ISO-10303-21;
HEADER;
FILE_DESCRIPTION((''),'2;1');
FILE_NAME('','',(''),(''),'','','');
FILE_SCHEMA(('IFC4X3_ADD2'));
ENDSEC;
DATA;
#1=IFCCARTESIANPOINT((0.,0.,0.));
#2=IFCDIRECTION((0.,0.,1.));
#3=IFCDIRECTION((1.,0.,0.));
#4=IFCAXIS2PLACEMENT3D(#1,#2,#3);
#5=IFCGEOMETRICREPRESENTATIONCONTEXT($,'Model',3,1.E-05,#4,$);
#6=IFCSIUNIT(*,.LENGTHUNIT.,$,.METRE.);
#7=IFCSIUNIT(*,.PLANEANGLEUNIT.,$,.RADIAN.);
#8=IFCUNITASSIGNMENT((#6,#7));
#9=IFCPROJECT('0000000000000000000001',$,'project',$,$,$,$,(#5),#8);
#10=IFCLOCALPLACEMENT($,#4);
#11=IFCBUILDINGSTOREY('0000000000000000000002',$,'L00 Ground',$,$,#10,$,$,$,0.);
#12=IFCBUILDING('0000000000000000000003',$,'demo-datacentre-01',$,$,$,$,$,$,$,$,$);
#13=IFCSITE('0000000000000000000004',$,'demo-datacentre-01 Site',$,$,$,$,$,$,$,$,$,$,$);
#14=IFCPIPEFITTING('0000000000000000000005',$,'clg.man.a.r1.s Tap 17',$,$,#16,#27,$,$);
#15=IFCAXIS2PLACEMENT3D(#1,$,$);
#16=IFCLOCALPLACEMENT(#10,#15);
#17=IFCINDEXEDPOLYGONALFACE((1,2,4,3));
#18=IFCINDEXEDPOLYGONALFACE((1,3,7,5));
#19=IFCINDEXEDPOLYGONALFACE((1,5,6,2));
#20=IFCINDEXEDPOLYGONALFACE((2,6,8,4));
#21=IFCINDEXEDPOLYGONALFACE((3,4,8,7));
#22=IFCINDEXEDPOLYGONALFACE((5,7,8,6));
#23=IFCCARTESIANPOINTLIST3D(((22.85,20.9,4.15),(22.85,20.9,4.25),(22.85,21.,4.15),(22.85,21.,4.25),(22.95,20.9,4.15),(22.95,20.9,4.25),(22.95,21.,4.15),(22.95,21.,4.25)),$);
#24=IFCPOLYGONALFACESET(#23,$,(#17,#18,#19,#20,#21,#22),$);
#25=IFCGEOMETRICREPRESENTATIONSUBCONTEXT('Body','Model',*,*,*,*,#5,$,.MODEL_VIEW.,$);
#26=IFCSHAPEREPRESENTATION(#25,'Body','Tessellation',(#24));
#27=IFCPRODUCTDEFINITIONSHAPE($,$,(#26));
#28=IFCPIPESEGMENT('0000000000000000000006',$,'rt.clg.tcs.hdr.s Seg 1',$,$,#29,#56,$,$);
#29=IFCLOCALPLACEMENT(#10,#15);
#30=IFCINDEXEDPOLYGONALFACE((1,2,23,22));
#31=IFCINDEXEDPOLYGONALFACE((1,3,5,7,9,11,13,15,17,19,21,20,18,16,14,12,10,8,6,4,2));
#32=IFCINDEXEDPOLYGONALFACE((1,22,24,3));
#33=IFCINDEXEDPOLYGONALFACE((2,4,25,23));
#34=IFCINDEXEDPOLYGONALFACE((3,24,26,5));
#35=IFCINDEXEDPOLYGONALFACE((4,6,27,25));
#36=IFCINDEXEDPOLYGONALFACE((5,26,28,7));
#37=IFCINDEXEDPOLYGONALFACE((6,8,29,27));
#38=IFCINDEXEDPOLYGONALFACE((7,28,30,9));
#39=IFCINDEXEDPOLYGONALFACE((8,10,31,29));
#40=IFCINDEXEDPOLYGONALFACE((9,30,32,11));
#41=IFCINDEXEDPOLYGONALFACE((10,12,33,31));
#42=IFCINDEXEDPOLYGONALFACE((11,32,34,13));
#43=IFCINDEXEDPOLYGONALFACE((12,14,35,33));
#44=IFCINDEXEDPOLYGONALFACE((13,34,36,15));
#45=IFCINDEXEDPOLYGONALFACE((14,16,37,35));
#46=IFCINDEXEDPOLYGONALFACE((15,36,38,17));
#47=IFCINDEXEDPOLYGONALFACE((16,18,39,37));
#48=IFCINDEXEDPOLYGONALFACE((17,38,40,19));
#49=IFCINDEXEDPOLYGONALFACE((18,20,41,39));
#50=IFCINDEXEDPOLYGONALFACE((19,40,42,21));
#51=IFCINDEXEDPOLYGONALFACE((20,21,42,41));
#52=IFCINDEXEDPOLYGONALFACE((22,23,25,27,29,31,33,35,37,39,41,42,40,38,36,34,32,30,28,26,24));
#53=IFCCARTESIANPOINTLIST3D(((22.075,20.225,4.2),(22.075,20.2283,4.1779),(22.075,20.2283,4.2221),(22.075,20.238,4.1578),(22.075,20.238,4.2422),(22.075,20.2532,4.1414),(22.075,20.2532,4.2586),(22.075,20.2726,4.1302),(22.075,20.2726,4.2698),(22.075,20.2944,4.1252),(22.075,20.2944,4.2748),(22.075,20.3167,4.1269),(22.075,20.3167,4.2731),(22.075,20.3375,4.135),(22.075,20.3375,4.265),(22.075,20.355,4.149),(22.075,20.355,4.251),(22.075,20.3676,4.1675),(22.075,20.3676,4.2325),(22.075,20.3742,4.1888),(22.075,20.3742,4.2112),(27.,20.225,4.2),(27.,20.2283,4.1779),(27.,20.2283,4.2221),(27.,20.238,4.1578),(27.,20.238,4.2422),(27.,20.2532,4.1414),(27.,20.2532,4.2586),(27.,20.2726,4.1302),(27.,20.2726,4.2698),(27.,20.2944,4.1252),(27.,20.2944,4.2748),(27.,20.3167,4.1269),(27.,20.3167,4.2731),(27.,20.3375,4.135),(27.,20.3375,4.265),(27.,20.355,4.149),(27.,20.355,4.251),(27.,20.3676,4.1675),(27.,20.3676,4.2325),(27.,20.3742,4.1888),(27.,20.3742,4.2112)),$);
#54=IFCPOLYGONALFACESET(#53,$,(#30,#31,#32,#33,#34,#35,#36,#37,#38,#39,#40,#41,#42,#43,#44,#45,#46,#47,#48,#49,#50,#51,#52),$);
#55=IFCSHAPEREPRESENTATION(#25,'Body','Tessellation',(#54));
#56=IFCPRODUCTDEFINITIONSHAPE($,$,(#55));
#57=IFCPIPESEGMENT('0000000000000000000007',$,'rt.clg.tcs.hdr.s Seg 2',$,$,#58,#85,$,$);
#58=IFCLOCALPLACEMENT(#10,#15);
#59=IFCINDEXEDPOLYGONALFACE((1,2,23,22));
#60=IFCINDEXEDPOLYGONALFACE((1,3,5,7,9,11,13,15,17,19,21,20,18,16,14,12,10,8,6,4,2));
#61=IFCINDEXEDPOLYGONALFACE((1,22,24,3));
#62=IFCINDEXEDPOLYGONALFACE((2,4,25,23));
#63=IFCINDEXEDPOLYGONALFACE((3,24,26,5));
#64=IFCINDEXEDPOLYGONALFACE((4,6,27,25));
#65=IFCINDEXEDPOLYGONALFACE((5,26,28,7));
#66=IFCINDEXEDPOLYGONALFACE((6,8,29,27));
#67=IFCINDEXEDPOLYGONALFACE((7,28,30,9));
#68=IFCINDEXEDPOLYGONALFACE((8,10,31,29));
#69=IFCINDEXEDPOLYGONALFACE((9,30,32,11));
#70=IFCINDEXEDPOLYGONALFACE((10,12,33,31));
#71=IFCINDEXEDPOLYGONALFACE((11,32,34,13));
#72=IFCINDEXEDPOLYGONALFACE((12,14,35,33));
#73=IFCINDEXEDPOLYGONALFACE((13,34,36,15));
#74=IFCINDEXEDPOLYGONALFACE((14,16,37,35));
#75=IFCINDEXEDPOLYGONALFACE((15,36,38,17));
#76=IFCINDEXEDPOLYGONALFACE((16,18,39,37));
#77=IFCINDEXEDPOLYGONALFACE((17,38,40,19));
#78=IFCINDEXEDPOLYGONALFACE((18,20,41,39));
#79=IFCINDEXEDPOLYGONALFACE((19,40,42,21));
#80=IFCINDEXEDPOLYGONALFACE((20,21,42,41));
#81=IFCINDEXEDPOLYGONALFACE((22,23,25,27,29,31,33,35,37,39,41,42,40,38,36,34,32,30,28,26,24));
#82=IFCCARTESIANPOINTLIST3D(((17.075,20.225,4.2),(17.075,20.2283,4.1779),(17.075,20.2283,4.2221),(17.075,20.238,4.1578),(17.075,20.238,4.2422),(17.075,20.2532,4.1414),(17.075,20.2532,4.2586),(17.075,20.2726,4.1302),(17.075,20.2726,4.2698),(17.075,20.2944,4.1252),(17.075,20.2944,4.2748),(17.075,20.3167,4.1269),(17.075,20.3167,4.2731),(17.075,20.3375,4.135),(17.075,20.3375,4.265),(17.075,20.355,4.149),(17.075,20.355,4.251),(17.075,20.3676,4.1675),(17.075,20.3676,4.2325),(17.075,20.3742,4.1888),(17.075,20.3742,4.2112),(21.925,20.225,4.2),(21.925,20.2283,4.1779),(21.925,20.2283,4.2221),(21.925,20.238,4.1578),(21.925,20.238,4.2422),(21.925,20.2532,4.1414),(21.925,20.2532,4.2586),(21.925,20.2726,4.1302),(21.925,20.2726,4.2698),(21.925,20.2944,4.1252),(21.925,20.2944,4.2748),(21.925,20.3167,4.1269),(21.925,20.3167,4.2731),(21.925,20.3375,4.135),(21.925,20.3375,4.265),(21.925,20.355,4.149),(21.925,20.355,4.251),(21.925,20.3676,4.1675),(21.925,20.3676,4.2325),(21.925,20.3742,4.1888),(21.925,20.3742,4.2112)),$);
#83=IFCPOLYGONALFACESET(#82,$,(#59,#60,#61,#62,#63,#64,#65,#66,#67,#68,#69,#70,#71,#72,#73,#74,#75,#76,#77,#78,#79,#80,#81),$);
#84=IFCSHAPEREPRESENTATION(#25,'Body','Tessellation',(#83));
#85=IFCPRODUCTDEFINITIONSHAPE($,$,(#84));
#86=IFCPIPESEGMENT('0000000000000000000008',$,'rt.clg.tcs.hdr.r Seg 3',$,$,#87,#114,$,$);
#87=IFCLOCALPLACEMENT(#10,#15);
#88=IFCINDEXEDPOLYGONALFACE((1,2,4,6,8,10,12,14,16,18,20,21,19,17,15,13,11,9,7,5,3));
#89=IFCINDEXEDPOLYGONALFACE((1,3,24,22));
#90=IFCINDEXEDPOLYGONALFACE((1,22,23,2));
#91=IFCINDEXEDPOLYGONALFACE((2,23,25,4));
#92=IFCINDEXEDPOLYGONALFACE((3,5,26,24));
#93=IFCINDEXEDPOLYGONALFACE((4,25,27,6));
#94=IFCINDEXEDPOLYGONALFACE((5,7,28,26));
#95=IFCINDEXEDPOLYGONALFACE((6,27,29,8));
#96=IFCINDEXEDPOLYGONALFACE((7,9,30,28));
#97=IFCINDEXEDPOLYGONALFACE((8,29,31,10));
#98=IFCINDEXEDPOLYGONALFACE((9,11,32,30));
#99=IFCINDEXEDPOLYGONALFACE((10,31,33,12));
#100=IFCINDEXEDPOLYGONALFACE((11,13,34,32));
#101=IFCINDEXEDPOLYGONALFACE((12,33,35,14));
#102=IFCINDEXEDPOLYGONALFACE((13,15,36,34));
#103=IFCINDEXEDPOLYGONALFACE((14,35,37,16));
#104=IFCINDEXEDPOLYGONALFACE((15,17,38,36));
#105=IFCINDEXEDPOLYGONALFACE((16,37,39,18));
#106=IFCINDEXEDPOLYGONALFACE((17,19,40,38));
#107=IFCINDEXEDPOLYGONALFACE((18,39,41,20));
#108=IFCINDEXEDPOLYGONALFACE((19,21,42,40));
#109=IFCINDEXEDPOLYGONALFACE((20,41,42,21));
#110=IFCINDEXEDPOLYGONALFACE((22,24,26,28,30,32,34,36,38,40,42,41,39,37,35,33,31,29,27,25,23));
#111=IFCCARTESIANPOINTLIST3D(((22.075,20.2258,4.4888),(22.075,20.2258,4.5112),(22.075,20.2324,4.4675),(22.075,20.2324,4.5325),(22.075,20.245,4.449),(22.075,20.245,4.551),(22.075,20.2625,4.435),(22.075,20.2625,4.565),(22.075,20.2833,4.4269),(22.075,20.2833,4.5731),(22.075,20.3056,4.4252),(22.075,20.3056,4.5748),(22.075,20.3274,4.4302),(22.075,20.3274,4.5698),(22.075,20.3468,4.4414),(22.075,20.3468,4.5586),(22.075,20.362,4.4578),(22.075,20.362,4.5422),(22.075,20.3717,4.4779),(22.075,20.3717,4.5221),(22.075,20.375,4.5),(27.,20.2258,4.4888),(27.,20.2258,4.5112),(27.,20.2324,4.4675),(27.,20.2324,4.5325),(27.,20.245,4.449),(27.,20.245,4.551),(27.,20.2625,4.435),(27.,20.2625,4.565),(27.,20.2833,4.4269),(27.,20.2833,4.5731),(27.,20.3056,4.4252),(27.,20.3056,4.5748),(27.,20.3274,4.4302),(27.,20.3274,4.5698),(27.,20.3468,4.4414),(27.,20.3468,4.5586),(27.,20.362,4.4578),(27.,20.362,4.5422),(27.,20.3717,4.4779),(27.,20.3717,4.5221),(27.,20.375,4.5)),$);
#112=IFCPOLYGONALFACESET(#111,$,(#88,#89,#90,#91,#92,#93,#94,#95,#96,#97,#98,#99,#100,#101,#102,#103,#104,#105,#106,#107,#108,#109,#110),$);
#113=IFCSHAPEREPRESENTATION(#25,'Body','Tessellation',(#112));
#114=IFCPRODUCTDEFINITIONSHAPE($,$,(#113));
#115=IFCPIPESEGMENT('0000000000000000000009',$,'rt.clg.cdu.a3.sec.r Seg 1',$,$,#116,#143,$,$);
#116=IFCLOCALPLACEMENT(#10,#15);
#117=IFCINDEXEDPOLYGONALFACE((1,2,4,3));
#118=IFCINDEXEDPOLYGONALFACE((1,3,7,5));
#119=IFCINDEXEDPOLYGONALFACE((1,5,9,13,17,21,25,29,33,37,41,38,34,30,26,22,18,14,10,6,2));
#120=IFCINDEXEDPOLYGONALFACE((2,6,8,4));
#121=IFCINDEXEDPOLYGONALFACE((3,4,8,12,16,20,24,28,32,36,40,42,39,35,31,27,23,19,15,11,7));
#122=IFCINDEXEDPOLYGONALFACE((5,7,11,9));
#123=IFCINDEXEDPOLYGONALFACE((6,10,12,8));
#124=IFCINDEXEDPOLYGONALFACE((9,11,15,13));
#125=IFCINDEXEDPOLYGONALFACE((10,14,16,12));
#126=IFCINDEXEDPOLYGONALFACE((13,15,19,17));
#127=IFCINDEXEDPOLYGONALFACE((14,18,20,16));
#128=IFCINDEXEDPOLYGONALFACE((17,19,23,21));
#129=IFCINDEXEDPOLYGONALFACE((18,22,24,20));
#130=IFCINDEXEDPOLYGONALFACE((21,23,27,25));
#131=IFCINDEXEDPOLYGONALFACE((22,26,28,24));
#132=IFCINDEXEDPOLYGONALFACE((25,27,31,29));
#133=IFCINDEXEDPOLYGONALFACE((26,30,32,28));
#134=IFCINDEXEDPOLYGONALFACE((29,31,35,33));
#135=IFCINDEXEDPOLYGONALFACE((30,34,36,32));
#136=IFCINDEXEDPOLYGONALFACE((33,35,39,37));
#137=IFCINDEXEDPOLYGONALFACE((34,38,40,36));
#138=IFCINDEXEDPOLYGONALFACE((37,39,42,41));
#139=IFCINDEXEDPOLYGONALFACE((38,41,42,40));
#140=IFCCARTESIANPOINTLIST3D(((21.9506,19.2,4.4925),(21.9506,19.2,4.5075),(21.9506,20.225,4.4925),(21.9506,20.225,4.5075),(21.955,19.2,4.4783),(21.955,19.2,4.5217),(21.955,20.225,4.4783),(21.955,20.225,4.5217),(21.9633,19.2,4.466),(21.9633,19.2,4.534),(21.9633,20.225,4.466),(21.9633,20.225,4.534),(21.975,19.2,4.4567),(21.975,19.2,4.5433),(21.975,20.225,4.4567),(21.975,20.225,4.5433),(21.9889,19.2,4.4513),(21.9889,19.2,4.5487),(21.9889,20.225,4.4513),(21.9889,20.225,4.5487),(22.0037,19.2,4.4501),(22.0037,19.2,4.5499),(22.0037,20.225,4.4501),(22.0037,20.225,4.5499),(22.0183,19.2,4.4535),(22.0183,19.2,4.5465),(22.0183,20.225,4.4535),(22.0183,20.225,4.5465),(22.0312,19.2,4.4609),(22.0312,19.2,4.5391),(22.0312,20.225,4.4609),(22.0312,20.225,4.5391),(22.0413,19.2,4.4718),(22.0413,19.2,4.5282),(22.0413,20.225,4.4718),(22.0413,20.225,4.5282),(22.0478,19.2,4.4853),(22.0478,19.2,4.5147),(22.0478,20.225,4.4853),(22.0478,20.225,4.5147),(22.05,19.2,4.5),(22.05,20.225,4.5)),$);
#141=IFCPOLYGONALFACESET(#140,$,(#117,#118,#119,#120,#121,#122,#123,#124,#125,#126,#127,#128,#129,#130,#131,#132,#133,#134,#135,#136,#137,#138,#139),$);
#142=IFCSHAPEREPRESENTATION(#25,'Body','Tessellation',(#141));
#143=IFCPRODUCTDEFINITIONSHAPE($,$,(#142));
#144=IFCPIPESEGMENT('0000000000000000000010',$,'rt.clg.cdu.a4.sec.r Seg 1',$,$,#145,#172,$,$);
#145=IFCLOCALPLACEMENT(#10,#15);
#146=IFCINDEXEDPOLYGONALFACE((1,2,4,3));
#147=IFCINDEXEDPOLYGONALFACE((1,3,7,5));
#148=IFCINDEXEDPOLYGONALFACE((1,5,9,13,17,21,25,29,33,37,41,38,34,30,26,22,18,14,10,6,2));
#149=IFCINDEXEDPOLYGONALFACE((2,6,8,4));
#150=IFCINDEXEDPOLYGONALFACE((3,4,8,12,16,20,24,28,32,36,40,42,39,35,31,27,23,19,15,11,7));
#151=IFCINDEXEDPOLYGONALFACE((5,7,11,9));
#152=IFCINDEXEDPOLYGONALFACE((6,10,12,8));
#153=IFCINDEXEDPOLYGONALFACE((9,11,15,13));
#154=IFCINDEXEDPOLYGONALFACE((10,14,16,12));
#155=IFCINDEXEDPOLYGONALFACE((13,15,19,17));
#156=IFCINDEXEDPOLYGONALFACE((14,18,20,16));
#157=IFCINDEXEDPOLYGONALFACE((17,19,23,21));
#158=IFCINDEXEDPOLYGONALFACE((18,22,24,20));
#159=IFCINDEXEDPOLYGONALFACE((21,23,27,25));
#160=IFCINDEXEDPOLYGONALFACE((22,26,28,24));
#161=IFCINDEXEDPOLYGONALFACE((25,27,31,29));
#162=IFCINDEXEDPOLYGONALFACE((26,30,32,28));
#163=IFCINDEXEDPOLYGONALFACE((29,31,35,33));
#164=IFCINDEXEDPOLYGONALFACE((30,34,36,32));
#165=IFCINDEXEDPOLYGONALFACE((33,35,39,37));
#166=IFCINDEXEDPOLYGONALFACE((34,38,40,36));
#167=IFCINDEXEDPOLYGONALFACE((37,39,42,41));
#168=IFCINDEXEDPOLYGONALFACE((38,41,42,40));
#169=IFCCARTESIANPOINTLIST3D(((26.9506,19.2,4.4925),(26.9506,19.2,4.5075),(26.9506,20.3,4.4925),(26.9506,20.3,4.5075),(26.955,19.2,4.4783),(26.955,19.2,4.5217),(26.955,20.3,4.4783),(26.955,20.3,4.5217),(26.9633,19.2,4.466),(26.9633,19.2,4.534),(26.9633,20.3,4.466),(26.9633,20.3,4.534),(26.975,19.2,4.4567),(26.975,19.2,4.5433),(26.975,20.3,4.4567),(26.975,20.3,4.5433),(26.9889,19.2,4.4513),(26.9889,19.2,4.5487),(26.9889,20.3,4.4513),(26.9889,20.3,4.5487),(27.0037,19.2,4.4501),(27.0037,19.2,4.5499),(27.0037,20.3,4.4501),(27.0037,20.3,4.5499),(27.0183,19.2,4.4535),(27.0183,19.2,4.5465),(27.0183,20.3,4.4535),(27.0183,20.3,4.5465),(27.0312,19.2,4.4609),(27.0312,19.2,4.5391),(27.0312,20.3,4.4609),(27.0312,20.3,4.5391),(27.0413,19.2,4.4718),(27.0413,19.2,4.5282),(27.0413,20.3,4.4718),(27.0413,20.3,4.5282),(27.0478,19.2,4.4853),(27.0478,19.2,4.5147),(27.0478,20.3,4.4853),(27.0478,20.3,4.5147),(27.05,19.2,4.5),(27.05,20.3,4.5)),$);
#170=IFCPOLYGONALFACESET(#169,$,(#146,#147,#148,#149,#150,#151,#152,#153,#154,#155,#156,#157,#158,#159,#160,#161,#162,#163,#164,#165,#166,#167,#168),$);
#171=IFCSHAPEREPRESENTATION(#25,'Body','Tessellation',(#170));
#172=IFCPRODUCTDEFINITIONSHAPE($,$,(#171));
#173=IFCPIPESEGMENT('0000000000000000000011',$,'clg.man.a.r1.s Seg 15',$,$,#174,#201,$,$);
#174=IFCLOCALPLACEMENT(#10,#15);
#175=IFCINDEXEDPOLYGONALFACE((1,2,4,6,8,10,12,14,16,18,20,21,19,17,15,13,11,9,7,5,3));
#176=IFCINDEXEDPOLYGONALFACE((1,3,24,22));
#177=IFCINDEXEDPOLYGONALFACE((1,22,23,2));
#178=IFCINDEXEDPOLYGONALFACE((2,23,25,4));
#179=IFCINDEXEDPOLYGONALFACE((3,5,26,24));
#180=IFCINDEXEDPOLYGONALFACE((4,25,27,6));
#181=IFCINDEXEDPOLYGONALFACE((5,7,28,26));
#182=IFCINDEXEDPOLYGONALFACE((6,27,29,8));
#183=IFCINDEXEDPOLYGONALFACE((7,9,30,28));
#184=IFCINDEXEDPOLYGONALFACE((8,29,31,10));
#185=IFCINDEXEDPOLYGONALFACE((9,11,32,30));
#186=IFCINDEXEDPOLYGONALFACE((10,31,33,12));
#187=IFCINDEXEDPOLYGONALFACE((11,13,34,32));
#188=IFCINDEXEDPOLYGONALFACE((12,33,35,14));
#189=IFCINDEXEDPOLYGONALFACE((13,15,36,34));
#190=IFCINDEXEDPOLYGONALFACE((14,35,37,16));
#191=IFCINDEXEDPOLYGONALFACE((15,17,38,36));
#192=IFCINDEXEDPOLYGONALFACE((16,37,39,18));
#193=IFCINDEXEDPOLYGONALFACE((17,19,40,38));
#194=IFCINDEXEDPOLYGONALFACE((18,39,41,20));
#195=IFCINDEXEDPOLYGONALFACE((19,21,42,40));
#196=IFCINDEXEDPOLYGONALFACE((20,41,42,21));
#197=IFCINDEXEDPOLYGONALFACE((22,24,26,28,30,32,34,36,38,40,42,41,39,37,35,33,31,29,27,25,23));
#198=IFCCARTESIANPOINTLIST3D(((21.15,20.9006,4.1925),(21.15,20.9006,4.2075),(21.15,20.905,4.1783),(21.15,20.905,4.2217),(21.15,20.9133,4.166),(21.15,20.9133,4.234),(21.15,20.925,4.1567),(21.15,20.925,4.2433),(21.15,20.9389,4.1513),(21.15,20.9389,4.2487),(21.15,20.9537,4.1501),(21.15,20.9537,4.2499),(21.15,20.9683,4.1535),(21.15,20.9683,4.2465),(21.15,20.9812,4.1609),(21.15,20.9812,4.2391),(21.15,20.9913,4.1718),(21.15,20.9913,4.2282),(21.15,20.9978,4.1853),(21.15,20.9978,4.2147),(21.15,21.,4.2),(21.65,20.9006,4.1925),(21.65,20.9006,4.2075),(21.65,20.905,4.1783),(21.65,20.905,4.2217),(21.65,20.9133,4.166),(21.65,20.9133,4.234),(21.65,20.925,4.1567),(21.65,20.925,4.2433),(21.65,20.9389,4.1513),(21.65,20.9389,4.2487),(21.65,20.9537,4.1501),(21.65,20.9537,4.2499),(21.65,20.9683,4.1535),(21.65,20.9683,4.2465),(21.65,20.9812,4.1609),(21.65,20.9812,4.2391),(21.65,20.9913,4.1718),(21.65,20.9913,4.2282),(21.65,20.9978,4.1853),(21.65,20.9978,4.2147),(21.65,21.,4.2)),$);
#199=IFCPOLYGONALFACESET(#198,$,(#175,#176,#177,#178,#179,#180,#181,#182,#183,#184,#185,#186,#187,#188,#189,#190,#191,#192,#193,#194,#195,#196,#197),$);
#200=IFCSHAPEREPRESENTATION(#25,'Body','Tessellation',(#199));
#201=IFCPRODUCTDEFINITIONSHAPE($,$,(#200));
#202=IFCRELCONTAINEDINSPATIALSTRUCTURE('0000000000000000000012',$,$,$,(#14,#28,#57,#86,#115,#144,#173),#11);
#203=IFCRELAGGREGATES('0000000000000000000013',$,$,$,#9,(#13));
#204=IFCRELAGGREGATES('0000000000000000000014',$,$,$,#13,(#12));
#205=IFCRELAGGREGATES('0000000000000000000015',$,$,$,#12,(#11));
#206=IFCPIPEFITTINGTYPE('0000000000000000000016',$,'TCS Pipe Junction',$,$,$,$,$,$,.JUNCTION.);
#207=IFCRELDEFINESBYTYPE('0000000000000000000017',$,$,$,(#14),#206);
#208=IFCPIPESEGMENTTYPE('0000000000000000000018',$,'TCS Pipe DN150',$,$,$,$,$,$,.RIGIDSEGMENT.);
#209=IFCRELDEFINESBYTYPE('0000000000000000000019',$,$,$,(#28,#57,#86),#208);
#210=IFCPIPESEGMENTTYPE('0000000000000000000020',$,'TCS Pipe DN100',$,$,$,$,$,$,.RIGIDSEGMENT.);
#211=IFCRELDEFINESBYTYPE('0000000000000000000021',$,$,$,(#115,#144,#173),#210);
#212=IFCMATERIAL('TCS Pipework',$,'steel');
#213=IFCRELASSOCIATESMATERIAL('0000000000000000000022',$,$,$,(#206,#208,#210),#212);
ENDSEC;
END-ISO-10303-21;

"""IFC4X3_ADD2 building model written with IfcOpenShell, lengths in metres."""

from ifc_helpers import new_model, si_unit, frame, origin_with_axes, place, context, subcontext, project, spatial, rectangle, circle, extrude, material, type_object, element, save


model = new_model("IFC4X3_ADD2")

# Units and contexts
model_context = context("Model", 3, precision=1e-05, world=origin_with_axes())
body_context = subcontext(model_context, "Body", "Model", "MODEL_VIEW")
ifc_project = project(units=[si_unit("LENGTHUNIT", "METRE"), si_unit("PLANEANGLEUNIT", "RADIAN")], contexts=[model_context])

# Site, building, storey
site = spatial("IfcSite", under=ifc_project, Name="demo-datacentre-01 Site")
building = spatial("IfcBuilding", under=site, Name="demo-datacentre-01")
storey_placement = place(None, origin_with_axes())
storey = spatial("IfcBuildingStorey", under=building, at=storey_placement, Name="L00 Ground", Elevation=0.0)

# Pipe fitting
ifc_material_1 = material(Name="TCS Pipework", Category="steel")
pipe_fitting_type_1 = type_object("IfcPipeFittingType", Name="TCS Pipe Junction", PredefinedType="JUNCTION", material=ifc_material_1)
for number, where, z_axis, x_axis, name in (
    (1, (22.9, 20.95, 4.15), (0.0, 0.0, 1.0), (1.0, 0.0, 0.0), "clg.man.a.r1.s Tap 17"),
):
    element("IfcPipeFitting", number, at=place(storey_placement, frame(where, z_axis=z_axis, x_axis=x_axis)), inside=storey, type_object=pipe_fitting_type_1, Name=name, context=body_context, shape_type="SweptSolid", body=[
        extrude(rectangle(XDim=0.1, YDim=0.1), origin_with_axes(), (0.0, 0.0, 1.0), 0.1),
    ])

# Pipe segments
pipe_segment_type_1 = type_object("IfcPipeSegmentType", Name="TCS Pipe DN150", PredefinedType="RIGIDSEGMENT", material=ifc_material_1)
pipe_segment_1_placement = place(storey_placement, frame((27.0, 20.3, 4.2), z_axis=(-1.0, 0.0, 0.0), x_axis=(0.0, -1.0, 0.0)))
element("IfcPipeSegment", 2, at=pipe_segment_1_placement, inside=storey, type_object=pipe_segment_type_1, Name="rt.clg.tcs.hdr.s Seg 1", context=body_context, shape_type="SweptSolid", body=[
    extrude(circle(Radius=0.075), origin_with_axes(), (0.0, 0.0, 1.0), 4.925),
])
pipe_segment_2_placement = place(storey_placement, frame((21.925, 20.3, 4.2), z_axis=(-1.0, 0.0, 0.0), x_axis=(0.0, -1.0, 0.0)))
element("IfcPipeSegment", 3, at=pipe_segment_2_placement, inside=storey, type_object=pipe_segment_type_1, Name="rt.clg.tcs.hdr.s Seg 2", context=body_context, shape_type="SweptSolid", body=[
    extrude(circle(Radius=0.075), origin_with_axes(), (0.0, 0.0, 1.0), 4.85),
])
pipe_segment_3_placement = place(storey_placement, frame((22.075, 20.3, 4.5), z_axis=(1.0, 0.0, 0.0), x_axis=(0.0, 1.0, 0.0)))
element("IfcPipeSegment", 4, at=pipe_segment_3_placement, inside=storey, type_object=pipe_segment_type_1, Name="rt.clg.tcs.hdr.r Seg 3", context=body_context, shape_type="SweptSolid", body=[
    extrude(circle(Radius=0.075), origin_with_axes(), (0.0, 0.0, 1.0), 4.925),
])
pipe_segment_type_2 = type_object("IfcPipeSegmentType", Name="TCS Pipe DN100", PredefinedType="RIGIDSEGMENT", material=ifc_material_1)
pipe_segment_4_placement = place(storey_placement, frame((22.0, 20.225, 4.5), z_axis=(0.0, -1.0, 0.0), x_axis=(1.0, 0.0, 0.0)))
element("IfcPipeSegment", 5, at=pipe_segment_4_placement, inside=storey, type_object=pipe_segment_type_2, Name="rt.clg.cdu.a3.sec.r Seg 1", context=body_context, shape_type="SweptSolid", body=[
    extrude(circle(Radius=0.05), origin_with_axes(), (0.0, 0.0, 1.0), 1.025),
])
pipe_segment_5_placement = place(storey_placement, frame((27.0, 20.3, 4.5), z_axis=(0.0, -1.0, 0.0), x_axis=(1.0, 0.0, 0.0)))
element("IfcPipeSegment", 6, at=pipe_segment_5_placement, inside=storey, type_object=pipe_segment_type_2, Name="rt.clg.cdu.a4.sec.r Seg 1", context=body_context, shape_type="SweptSolid", body=[
    extrude(circle(Radius=0.05), origin_with_axes(), (0.0, 0.0, 1.0), 1.1),
])
pipe_segment_6_placement = place(storey_placement, frame((21.15, 20.95, 4.2), z_axis=(1.0, 0.0, 0.0), x_axis=(0.0, 1.0, 0.0)))
element("IfcPipeSegment", 7, at=pipe_segment_6_placement, inside=storey, type_object=pipe_segment_type_2, Name="clg.man.a.r1.s Seg 15", context=body_context, shape_type="SweptSolid", body=[
    extrude(circle(Radius=0.05), origin_with_axes(), (0.0, 0.0, 1.0), 0.5),
])

save(model, "model.ifc")
